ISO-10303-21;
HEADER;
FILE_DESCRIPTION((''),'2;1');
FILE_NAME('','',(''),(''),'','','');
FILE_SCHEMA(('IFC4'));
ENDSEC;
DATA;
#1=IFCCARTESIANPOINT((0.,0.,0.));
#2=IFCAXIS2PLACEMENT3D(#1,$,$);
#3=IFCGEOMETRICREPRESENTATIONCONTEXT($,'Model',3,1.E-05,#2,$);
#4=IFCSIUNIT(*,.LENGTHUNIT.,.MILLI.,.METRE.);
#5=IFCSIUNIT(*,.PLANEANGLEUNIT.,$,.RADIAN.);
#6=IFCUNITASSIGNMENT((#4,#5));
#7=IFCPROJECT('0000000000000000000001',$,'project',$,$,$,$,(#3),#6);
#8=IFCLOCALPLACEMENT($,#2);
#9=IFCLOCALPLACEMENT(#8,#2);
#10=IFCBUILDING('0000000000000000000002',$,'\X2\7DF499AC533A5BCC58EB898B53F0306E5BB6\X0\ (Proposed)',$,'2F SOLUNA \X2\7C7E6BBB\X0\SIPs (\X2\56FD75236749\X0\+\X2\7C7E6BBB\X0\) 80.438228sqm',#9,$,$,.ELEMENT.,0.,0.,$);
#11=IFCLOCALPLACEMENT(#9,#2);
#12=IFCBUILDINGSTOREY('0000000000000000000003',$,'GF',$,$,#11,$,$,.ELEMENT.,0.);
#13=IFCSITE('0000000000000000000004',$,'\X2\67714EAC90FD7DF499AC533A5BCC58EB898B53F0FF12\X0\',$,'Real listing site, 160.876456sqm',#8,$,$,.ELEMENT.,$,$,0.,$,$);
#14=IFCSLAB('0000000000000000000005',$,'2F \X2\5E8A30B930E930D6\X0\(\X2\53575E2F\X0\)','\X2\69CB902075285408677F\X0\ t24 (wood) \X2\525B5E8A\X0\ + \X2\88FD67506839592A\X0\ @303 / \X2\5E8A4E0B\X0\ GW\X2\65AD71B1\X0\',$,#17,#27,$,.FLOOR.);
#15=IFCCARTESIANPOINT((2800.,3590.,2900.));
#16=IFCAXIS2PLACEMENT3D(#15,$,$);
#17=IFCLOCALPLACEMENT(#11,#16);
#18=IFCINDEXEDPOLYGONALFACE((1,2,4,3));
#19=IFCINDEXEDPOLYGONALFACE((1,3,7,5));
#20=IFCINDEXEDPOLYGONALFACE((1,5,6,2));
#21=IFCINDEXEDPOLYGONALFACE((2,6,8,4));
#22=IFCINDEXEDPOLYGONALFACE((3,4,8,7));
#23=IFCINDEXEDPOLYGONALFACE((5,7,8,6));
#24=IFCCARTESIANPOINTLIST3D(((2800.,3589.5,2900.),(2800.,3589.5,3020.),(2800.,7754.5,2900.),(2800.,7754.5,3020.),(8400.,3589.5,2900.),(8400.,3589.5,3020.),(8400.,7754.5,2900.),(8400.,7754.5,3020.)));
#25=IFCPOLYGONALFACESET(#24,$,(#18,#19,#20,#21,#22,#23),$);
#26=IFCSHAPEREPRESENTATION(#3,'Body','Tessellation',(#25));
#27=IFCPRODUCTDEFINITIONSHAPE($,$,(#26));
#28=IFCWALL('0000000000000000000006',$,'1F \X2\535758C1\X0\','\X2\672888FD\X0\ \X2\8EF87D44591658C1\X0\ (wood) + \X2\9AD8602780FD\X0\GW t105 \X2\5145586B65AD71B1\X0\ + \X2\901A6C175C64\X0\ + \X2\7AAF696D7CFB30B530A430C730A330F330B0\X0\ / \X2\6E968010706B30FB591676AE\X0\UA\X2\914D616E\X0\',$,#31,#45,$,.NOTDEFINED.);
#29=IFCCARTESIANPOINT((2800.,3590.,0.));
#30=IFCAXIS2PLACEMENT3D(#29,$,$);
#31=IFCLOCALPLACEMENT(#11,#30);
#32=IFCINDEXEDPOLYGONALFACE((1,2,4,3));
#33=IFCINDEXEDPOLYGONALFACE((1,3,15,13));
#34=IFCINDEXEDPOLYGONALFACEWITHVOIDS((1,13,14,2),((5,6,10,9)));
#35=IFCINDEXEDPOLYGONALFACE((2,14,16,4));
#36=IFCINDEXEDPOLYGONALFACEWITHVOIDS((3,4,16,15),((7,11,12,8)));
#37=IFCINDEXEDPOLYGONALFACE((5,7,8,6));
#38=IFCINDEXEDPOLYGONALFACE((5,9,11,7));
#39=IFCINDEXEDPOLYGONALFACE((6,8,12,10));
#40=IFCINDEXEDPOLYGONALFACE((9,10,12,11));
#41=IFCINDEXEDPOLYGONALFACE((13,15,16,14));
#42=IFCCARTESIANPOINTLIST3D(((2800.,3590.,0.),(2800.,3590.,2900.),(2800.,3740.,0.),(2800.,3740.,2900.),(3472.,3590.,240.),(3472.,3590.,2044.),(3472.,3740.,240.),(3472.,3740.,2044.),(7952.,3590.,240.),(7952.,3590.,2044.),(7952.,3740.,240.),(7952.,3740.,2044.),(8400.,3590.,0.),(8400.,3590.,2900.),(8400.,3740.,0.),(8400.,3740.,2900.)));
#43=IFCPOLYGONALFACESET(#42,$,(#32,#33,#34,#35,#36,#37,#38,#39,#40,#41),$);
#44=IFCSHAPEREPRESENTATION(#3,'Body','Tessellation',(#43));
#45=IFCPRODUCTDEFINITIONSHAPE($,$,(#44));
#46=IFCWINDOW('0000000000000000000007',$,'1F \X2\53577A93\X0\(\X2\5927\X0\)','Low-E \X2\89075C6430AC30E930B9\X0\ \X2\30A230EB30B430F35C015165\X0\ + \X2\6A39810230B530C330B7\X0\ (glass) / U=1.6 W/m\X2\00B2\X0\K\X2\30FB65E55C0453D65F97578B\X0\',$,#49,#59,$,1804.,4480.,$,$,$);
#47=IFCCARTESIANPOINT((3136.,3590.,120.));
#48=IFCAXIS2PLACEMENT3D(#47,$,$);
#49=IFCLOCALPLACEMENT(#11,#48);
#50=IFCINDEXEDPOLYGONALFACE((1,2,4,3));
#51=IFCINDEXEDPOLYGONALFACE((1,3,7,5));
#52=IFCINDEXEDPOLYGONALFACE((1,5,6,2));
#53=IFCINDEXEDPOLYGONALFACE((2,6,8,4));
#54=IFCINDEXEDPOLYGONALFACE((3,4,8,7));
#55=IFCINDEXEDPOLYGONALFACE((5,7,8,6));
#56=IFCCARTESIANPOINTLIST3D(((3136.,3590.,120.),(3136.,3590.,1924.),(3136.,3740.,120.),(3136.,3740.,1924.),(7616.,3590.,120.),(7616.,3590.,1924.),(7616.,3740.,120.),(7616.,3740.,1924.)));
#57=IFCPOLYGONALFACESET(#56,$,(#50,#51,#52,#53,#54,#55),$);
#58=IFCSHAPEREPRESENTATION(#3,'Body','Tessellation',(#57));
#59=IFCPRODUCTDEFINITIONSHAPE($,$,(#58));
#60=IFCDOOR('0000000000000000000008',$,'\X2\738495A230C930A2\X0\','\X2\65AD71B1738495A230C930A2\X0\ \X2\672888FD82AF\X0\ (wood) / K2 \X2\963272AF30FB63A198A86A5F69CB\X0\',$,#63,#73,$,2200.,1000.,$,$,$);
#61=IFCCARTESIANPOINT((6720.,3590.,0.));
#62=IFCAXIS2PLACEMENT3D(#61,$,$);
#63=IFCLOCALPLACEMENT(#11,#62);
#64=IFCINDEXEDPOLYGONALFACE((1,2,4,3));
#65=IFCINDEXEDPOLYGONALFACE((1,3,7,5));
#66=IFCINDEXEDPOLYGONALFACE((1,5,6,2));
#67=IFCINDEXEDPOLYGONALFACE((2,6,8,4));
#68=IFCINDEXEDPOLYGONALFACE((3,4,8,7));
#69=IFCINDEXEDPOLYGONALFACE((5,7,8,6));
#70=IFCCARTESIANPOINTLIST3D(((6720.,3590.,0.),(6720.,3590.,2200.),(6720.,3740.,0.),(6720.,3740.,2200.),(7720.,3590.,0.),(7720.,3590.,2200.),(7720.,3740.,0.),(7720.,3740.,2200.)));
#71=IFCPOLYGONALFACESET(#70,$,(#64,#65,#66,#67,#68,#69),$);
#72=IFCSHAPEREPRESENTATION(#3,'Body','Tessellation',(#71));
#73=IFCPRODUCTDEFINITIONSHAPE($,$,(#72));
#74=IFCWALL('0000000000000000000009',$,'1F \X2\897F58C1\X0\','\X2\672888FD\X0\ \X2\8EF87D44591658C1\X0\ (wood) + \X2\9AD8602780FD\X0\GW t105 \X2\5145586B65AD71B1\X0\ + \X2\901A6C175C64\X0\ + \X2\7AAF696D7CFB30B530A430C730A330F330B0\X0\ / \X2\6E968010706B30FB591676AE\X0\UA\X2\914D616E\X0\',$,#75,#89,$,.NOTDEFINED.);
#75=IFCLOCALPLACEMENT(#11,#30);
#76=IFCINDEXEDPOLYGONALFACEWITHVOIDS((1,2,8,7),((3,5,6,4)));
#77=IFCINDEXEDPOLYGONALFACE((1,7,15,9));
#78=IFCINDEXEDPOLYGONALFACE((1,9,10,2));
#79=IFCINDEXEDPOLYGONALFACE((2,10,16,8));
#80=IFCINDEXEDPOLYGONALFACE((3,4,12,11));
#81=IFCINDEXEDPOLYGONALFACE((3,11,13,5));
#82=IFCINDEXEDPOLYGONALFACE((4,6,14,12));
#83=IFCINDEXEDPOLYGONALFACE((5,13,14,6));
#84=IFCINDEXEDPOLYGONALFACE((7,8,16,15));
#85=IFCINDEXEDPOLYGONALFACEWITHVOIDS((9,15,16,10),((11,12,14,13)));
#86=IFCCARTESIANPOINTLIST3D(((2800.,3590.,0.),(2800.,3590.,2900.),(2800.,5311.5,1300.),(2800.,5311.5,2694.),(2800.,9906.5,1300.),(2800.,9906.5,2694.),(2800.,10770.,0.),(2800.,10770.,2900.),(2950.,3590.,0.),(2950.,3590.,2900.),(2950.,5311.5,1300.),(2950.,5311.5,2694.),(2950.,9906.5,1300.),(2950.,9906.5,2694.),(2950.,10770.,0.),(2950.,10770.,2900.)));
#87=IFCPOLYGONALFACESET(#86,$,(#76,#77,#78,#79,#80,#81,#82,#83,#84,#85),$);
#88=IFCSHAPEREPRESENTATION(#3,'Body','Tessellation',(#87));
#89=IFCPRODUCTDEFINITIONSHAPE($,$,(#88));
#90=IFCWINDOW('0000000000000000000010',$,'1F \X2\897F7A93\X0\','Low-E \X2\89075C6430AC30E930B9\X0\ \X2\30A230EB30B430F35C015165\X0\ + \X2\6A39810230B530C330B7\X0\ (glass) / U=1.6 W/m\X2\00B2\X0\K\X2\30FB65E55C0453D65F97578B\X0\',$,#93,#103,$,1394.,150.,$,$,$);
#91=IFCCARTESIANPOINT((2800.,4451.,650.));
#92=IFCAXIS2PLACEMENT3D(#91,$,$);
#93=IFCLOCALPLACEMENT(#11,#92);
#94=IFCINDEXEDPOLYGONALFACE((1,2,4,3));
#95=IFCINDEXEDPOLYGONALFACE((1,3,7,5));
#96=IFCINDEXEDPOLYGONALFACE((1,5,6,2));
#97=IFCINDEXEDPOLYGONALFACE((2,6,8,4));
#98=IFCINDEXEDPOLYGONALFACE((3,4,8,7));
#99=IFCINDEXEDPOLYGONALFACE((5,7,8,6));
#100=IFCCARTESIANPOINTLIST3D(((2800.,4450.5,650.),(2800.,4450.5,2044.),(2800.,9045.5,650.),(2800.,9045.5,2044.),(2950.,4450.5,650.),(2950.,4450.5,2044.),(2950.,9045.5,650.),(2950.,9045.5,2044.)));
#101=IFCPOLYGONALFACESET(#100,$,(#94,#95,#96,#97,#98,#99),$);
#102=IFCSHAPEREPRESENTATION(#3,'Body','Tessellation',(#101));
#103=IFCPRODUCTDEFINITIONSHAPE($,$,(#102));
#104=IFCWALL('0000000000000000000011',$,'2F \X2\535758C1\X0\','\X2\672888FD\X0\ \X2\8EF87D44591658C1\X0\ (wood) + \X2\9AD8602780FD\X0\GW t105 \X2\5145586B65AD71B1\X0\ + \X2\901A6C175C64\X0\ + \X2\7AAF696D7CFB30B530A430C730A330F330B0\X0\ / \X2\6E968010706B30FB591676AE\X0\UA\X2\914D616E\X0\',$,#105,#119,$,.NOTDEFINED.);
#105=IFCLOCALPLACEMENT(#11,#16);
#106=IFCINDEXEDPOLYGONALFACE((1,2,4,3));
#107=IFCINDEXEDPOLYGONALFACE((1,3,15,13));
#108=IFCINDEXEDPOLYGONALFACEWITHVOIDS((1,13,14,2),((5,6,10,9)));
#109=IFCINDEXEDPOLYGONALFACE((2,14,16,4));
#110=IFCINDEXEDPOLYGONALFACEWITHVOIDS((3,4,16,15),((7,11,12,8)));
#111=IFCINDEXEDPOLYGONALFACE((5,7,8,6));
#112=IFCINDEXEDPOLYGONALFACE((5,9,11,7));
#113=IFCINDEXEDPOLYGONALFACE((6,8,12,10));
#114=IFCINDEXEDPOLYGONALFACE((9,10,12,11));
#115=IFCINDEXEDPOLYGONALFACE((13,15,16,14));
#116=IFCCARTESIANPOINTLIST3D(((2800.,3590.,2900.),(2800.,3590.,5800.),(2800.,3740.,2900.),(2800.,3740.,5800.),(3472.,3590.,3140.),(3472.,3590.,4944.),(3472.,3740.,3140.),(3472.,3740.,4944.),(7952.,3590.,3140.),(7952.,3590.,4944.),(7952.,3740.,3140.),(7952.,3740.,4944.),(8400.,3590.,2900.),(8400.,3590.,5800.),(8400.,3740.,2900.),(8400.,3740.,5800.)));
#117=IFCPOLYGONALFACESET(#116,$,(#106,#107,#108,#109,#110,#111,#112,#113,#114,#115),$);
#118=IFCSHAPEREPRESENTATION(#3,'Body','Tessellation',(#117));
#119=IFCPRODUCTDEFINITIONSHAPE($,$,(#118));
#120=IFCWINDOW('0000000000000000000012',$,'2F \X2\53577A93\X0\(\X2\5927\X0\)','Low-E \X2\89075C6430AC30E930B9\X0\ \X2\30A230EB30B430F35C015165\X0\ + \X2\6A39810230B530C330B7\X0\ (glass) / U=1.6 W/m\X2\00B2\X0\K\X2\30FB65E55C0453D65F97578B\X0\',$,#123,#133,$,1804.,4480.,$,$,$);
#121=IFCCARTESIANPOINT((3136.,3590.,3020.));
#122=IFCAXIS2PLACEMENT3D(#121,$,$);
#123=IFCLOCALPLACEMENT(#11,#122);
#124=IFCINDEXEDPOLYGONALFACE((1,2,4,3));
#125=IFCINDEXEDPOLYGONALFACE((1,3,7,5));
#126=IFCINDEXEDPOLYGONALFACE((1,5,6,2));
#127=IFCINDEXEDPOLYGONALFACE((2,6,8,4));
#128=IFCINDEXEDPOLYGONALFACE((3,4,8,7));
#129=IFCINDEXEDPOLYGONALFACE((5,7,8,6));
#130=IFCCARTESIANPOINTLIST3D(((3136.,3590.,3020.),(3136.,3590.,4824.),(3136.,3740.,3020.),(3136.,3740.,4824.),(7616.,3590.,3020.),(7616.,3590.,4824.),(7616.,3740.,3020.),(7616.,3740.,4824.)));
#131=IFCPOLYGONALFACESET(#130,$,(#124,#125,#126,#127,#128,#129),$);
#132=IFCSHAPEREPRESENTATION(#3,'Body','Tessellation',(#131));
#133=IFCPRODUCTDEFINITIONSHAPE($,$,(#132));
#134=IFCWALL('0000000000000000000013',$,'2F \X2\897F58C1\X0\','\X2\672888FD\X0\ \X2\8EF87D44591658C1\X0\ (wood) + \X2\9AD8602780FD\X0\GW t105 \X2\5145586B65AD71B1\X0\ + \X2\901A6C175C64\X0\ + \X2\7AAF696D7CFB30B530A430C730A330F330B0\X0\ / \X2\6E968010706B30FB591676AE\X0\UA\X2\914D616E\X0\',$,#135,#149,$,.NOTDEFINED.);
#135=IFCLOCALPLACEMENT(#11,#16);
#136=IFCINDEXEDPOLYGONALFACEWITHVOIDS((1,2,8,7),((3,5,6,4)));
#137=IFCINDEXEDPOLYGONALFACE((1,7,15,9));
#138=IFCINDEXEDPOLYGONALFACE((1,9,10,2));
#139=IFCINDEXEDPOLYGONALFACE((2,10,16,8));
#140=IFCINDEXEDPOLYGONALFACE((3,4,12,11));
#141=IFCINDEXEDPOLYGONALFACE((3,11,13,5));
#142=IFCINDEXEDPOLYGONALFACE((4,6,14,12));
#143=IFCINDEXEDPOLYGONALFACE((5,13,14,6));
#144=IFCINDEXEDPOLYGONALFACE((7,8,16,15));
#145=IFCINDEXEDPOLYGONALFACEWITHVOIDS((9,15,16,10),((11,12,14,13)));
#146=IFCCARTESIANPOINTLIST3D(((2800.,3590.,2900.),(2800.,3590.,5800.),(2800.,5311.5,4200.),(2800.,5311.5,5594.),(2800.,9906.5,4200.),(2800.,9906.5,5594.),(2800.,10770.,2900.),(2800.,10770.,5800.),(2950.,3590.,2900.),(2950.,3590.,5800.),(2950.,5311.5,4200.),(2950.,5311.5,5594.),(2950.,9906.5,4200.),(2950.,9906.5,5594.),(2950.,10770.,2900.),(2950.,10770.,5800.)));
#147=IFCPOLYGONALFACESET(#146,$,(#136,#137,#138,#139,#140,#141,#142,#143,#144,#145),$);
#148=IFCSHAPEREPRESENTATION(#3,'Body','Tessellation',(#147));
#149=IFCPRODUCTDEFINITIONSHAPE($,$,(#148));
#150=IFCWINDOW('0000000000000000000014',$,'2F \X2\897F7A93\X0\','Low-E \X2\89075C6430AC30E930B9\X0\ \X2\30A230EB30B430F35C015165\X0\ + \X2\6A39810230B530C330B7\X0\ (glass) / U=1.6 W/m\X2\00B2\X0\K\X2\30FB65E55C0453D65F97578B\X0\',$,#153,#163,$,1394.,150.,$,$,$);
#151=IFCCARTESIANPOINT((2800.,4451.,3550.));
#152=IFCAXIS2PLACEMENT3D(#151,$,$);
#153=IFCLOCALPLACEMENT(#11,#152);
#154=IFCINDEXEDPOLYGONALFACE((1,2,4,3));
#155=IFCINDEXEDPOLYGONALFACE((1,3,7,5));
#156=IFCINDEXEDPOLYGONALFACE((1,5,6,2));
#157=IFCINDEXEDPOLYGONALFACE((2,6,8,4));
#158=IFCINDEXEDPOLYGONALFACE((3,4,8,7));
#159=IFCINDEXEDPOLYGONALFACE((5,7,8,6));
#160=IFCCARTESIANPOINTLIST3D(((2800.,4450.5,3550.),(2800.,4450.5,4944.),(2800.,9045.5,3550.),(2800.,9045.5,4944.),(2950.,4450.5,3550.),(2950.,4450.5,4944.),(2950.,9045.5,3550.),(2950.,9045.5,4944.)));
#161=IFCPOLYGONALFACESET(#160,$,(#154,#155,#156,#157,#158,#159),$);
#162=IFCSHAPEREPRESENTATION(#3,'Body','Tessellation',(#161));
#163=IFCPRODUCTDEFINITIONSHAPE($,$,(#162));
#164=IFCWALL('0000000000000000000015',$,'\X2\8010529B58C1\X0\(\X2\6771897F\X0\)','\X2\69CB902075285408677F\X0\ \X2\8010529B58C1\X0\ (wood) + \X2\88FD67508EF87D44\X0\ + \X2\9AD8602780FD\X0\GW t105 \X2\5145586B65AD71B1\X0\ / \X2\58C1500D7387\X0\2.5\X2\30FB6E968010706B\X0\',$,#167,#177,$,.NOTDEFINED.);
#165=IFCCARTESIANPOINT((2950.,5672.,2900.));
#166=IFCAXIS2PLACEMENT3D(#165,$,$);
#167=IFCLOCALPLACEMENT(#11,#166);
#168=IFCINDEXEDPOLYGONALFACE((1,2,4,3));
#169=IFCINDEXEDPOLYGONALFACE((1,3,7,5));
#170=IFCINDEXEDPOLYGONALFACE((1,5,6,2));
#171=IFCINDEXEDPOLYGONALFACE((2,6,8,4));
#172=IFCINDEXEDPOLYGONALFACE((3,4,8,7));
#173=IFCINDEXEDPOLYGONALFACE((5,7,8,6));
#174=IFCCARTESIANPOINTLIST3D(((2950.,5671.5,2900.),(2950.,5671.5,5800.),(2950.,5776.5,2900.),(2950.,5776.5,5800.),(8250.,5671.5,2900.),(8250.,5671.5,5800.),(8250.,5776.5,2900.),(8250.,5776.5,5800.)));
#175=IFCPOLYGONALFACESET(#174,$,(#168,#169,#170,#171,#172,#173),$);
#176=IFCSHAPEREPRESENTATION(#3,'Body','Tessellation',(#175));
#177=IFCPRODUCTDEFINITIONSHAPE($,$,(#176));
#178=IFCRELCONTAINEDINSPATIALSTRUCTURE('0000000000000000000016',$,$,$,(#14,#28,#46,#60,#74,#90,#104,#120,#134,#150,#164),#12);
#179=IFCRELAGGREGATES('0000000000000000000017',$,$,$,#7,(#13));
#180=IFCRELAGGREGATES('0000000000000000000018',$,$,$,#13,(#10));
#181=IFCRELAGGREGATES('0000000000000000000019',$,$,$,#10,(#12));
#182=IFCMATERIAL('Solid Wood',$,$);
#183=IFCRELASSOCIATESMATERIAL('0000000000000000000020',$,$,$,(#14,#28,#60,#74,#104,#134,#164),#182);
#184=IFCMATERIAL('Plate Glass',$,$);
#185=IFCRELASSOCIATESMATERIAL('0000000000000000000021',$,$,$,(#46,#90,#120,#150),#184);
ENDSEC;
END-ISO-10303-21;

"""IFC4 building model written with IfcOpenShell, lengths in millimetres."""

from ifc_helpers import new_model, si_unit, frame, frame_2d, origin, place, context, project, spatial, rectangle, extrude, material, element, fill, save


model = new_model("IFC4")

# Units and contexts
model_context = context("Model", 3, precision=1e-05, world=origin())
ifc_project = project(units=[si_unit("LENGTHUNIT", "METRE", prefix="MILLI"), si_unit("PLANEANGLEUNIT", "RADIAN")], contexts=[model_context])

# Site, building, storey
site_placement = place(None, origin())
site = spatial("IfcSite", under=ifc_project, at=site_placement, Name="東京都練馬区富士見台２", ObjectType="Real listing site, 160.876456sqm", CompositionType="ELEMENT", RefElevation=0.0)
building_placement = place(site_placement, origin())
building = spatial("IfcBuilding", under=site, at=building_placement, Name="練馬区富士見台の家 (Proposed)", ObjectType="2F SOLUNA 籾殻SIPs (国産杉+籾殻) 80.438228sqm", CompositionType="ELEMENT", ElevationOfRefHeight=0.0, ElevationOfTerrain=0.0)
storey_placement = place(building_placement, origin())
storey = spatial("IfcBuildingStorey", under=building, at=storey_placement, Name="GF", CompositionType="ELEMENT", Elevation=0.0)

# Slab
ifc_material_1 = material(Name="Solid Wood")
slab_1_placement = place(storey_placement, frame((2800.0, 3590.0, 2900.0)))
element("IfcSlab", 1, at=slab_1_placement, inside=storey, material=ifc_material_1, Name="2F 床スラブ(南帯)", Description="構造用合板 t24 (wood) 剛床 + 製材根太 @303 / 床下 GW断熱", PredefinedType="FLOOR", context=model_context, shape_type="SweptSolid", body=[
    extrude(rectangle(XDim=5600.0, YDim=4165.0, at=frame_2d((2800.0, 2082.0))), frame((2800.0, 3590.0, 2900.0)), (0.0, 0.0, 1.0), 120.0),
])

# Wall, openings, window, door
wall_1_placement = place(storey_placement, frame((2800.0, 3590.0, 0.0)))
wall_1 = element("IfcWall", 2, at=wall_1_placement, inside=storey, material=ifc_material_1, Name="1F 南壁", Description="木製 軸組外壁 (wood) + 高性能GW t105 充填断熱 + 通気層 + 窯業系サイディング / 準耐火・外皮UA配慮", PredefinedType="NOTDEFINED", context=model_context, shape_type="SweptSolid", body=[
    extrude(rectangle(XDim=5600.0, YDim=150.0, at=frame_2d((2800.0, 75.0))), frame((2800.0, 3590.0, 0.0)), (0.0, 0.0, 1.0), 2900.0),
])
opening_1_placement = place(storey_placement, frame((3136.0, 3590.0, 120.0)))
opening_1 = element("IfcOpeningElement", 3, at=opening_1_placement, cuts=wall_1, PredefinedType="NOTDEFINED", context=model_context, shape_type="SweptSolid", body=[
    extrude(rectangle(XDim=4480.0, YDim=150.0, at=frame_2d((2240.0, 75.0))), frame((3136.0, 3590.0, 120.0)), (0.0, 0.0, 1.0), 1804.0),
])
opening_2_placement = place(storey_placement, frame((6720.0, 3590.0, 0.0)))
opening_2 = element("IfcOpeningElement", 4, at=opening_2_placement, cuts=wall_1, PredefinedType="NOTDEFINED", context=model_context, shape_type="SweptSolid", body=[
    extrude(rectangle(XDim=1000.0, YDim=150.0, at=frame_2d((500.0, 75.0))), frame((6720.0, 3590.0, 0.0)), (0.0, 0.0, 1.0), 2200.0),
])
ifc_material_2 = material(Name="Plate Glass")
window_1_placement = place(storey_placement, frame((3136.0, 3590.0, 120.0)))
window_1 = element("IfcWindow", 5, at=window_1_placement, inside=storey, material=ifc_material_2, Name="1F 南窓(大)", Description="Low-E 複層ガラス アルゴン封入 + 樹脂サッシ (glass) / U=1.6 W/m²K・日射取得型", OverallHeight=1804.0, OverallWidth=4480.0, context=model_context, shape_type="SweptSolid", body=[
    extrude(rectangle(XDim=4480.0, YDim=150.0, at=frame_2d((2240.0, 75.0))), frame((3136.0, 3590.0, 120.0)), (0.0, 0.0, 1.0), 1804.0),
])
fill(opening_1, window_1)
door_placement = place(storey_placement, frame((6720.0, 3590.0, 0.0)))
door = element("IfcDoor", 6, at=door_placement, inside=storey, material=ifc_material_1, Name="玄関ドア", Description="断熱玄関ドア 木製芯 (wood) / K2 防犯・採風機構", OverallHeight=2200.0, OverallWidth=1000.0, context=model_context, shape_type="SweptSolid", body=[
    extrude(rectangle(XDim=1000.0, YDim=150.0, at=frame_2d((500.0, 75.0))), frame((6720.0, 3590.0, 0.0)), (0.0, 0.0, 1.0), 2200.0),
])
fill(opening_2, door)

# Wall, opening, window
wall_2_placement = place(storey_placement, frame((2800.0, 3590.0, 0.0)))
wall_2 = element("IfcWall", 7, at=wall_2_placement, inside=storey, material=ifc_material_1, Name="1F 西壁", Description="木製 軸組外壁 (wood) + 高性能GW t105 充填断熱 + 通気層 + 窯業系サイディング / 準耐火・外皮UA配慮", PredefinedType="NOTDEFINED", context=model_context, shape_type="SweptSolid", body=[
    extrude(rectangle(XDim=150.0, YDim=7180.0, at=frame_2d((75.0, 3590.0))), frame((2800.0, 3590.0, 0.0)), (0.0, 0.0, 1.0), 2900.0),
])
opening_3_placement = place(storey_placement, frame((2800.0, 4451.0, 650.0)))
opening_3 = element("IfcOpeningElement", 8, at=opening_3_placement, cuts=wall_2, PredefinedType="NOTDEFINED", context=model_context, shape_type="SweptSolid", body=[
    extrude(rectangle(XDim=150.0, YDim=4595.0, at=frame_2d((75.0, 2297.0))), frame((2800.0, 4451.0, 650.0)), (0.0, 0.0, 1.0), 1394.0),
])
window_2_placement = place(storey_placement, frame((2800.0, 4451.0, 650.0)))
window_2 = element("IfcWindow", 9, at=window_2_placement, inside=storey, material=ifc_material_2, Name="1F 西窓", Description="Low-E 複層ガラス アルゴン封入 + 樹脂サッシ (glass) / U=1.6 W/m²K・日射取得型", OverallHeight=1394.0, OverallWidth=150.0, context=model_context, shape_type="SweptSolid", body=[
    extrude(rectangle(XDim=150.0, YDim=4595.0, at=frame_2d((75.0, 2297.0))), frame((2800.0, 4451.0, 650.0)), (0.0, 0.0, 1.0), 1394.0),
])
fill(opening_3, window_2)

# Walls, openings, windows
wall_3_placement = place(storey_placement, frame((2800.0, 3590.0, 2900.0)))
wall_3 = element("IfcWall", 10, at=wall_3_placement, inside=storey, material=ifc_material_1, Name="2F 南壁", Description="木製 軸組外壁 (wood) + 高性能GW t105 充填断熱 + 通気層 + 窯業系サイディング / 準耐火・外皮UA配慮", PredefinedType="NOTDEFINED", context=model_context, shape_type="SweptSolid", body=[
    extrude(rectangle(XDim=5600.0, YDim=150.0, at=frame_2d((2800.0, 75.0))), frame((2800.0, 3590.0, 2900.0)), (0.0, 0.0, 1.0), 2900.0),
])
opening_4_placement = place(storey_placement, frame((3136.0, 3590.0, 3020.0)))
opening_4 = element("IfcOpeningElement", 11, at=opening_4_placement, cuts=wall_3, PredefinedType="NOTDEFINED", context=model_context, shape_type="SweptSolid", body=[
    extrude(rectangle(XDim=4480.0, YDim=150.0, at=frame_2d((2240.0, 75.0))), frame((3136.0, 3590.0, 3020.0)), (0.0, 0.0, 1.0), 1804.0),
])
window_3_placement = place(storey_placement, frame((3136.0, 3590.0, 3020.0)))
window_3 = element("IfcWindow", 12, at=window_3_placement, inside=storey, material=ifc_material_2, Name="2F 南窓(大)", Description="Low-E 複層ガラス アルゴン封入 + 樹脂サッシ (glass) / U=1.6 W/m²K・日射取得型", OverallHeight=1804.0, OverallWidth=4480.0, context=model_context, shape_type="SweptSolid", body=[
    extrude(rectangle(XDim=4480.0, YDim=150.0, at=frame_2d((2240.0, 75.0))), frame((3136.0, 3590.0, 3020.0)), (0.0, 0.0, 1.0), 1804.0),
])
fill(opening_4, window_3)
wall_4_placement = place(storey_placement, frame((2800.0, 3590.0, 2900.0)))
wall_4 = element("IfcWall", 13, at=wall_4_placement, inside=storey, material=ifc_material_1, Name="2F 西壁", Description="木製 軸組外壁 (wood) + 高性能GW t105 充填断熱 + 通気層 + 窯業系サイディング / 準耐火・外皮UA配慮", PredefinedType="NOTDEFINED", context=model_context, shape_type="SweptSolid", body=[
    extrude(rectangle(XDim=150.0, YDim=7180.0, at=frame_2d((75.0, 3590.0))), frame((2800.0, 3590.0, 2900.0)), (0.0, 0.0, 1.0), 2900.0),
])
opening_5_placement = place(storey_placement, frame((2800.0, 4451.0, 3550.0)))
opening_5 = element("IfcOpeningElement", 14, at=opening_5_placement, cuts=wall_4, PredefinedType="NOTDEFINED", context=model_context, shape_type="SweptSolid", body=[
    extrude(rectangle(XDim=150.0, YDim=4595.0, at=frame_2d((75.0, 2297.0))), frame((2800.0, 4451.0, 3550.0)), (0.0, 0.0, 1.0), 1394.0),
])
window_4_placement = place(storey_placement, frame((2800.0, 4451.0, 3550.0)))
window_4 = element("IfcWindow", 15, at=window_4_placement, inside=storey, material=ifc_material_2, Name="2F 西窓", Description="Low-E 複層ガラス アルゴン封入 + 樹脂サッシ (glass) / U=1.6 W/m²K・日射取得型", OverallHeight=1394.0, OverallWidth=150.0, context=model_context, shape_type="SweptSolid", body=[
    extrude(rectangle(XDim=150.0, YDim=4595.0, at=frame_2d((75.0, 2297.0))), frame((2800.0, 4451.0, 3550.0)), (0.0, 0.0, 1.0), 1394.0),
])
fill(opening_5, window_4)

# Wall
wall_5_placement = place(storey_placement, frame((2950.0, 5672.0, 2900.0)))
element("IfcWall", 16, at=wall_5_placement, inside=storey, material=ifc_material_1, Name="耐力壁(東西)", Description="構造用合板 耐力壁 (wood) + 製材軸組 + 高性能GW t105 充填断熱 / 壁倍率2.5・準耐火", PredefinedType="NOTDEFINED", context=model_context, shape_type="SweptSolid", body=[
    extrude(rectangle(XDim=5300.0, YDim=105.0, at=frame_2d((2650.0, 52.0))), frame((2950.0, 5672.0, 2900.0)), (0.0, 0.0, 1.0), 2900.0),
])

save(model, "model.ifc")
